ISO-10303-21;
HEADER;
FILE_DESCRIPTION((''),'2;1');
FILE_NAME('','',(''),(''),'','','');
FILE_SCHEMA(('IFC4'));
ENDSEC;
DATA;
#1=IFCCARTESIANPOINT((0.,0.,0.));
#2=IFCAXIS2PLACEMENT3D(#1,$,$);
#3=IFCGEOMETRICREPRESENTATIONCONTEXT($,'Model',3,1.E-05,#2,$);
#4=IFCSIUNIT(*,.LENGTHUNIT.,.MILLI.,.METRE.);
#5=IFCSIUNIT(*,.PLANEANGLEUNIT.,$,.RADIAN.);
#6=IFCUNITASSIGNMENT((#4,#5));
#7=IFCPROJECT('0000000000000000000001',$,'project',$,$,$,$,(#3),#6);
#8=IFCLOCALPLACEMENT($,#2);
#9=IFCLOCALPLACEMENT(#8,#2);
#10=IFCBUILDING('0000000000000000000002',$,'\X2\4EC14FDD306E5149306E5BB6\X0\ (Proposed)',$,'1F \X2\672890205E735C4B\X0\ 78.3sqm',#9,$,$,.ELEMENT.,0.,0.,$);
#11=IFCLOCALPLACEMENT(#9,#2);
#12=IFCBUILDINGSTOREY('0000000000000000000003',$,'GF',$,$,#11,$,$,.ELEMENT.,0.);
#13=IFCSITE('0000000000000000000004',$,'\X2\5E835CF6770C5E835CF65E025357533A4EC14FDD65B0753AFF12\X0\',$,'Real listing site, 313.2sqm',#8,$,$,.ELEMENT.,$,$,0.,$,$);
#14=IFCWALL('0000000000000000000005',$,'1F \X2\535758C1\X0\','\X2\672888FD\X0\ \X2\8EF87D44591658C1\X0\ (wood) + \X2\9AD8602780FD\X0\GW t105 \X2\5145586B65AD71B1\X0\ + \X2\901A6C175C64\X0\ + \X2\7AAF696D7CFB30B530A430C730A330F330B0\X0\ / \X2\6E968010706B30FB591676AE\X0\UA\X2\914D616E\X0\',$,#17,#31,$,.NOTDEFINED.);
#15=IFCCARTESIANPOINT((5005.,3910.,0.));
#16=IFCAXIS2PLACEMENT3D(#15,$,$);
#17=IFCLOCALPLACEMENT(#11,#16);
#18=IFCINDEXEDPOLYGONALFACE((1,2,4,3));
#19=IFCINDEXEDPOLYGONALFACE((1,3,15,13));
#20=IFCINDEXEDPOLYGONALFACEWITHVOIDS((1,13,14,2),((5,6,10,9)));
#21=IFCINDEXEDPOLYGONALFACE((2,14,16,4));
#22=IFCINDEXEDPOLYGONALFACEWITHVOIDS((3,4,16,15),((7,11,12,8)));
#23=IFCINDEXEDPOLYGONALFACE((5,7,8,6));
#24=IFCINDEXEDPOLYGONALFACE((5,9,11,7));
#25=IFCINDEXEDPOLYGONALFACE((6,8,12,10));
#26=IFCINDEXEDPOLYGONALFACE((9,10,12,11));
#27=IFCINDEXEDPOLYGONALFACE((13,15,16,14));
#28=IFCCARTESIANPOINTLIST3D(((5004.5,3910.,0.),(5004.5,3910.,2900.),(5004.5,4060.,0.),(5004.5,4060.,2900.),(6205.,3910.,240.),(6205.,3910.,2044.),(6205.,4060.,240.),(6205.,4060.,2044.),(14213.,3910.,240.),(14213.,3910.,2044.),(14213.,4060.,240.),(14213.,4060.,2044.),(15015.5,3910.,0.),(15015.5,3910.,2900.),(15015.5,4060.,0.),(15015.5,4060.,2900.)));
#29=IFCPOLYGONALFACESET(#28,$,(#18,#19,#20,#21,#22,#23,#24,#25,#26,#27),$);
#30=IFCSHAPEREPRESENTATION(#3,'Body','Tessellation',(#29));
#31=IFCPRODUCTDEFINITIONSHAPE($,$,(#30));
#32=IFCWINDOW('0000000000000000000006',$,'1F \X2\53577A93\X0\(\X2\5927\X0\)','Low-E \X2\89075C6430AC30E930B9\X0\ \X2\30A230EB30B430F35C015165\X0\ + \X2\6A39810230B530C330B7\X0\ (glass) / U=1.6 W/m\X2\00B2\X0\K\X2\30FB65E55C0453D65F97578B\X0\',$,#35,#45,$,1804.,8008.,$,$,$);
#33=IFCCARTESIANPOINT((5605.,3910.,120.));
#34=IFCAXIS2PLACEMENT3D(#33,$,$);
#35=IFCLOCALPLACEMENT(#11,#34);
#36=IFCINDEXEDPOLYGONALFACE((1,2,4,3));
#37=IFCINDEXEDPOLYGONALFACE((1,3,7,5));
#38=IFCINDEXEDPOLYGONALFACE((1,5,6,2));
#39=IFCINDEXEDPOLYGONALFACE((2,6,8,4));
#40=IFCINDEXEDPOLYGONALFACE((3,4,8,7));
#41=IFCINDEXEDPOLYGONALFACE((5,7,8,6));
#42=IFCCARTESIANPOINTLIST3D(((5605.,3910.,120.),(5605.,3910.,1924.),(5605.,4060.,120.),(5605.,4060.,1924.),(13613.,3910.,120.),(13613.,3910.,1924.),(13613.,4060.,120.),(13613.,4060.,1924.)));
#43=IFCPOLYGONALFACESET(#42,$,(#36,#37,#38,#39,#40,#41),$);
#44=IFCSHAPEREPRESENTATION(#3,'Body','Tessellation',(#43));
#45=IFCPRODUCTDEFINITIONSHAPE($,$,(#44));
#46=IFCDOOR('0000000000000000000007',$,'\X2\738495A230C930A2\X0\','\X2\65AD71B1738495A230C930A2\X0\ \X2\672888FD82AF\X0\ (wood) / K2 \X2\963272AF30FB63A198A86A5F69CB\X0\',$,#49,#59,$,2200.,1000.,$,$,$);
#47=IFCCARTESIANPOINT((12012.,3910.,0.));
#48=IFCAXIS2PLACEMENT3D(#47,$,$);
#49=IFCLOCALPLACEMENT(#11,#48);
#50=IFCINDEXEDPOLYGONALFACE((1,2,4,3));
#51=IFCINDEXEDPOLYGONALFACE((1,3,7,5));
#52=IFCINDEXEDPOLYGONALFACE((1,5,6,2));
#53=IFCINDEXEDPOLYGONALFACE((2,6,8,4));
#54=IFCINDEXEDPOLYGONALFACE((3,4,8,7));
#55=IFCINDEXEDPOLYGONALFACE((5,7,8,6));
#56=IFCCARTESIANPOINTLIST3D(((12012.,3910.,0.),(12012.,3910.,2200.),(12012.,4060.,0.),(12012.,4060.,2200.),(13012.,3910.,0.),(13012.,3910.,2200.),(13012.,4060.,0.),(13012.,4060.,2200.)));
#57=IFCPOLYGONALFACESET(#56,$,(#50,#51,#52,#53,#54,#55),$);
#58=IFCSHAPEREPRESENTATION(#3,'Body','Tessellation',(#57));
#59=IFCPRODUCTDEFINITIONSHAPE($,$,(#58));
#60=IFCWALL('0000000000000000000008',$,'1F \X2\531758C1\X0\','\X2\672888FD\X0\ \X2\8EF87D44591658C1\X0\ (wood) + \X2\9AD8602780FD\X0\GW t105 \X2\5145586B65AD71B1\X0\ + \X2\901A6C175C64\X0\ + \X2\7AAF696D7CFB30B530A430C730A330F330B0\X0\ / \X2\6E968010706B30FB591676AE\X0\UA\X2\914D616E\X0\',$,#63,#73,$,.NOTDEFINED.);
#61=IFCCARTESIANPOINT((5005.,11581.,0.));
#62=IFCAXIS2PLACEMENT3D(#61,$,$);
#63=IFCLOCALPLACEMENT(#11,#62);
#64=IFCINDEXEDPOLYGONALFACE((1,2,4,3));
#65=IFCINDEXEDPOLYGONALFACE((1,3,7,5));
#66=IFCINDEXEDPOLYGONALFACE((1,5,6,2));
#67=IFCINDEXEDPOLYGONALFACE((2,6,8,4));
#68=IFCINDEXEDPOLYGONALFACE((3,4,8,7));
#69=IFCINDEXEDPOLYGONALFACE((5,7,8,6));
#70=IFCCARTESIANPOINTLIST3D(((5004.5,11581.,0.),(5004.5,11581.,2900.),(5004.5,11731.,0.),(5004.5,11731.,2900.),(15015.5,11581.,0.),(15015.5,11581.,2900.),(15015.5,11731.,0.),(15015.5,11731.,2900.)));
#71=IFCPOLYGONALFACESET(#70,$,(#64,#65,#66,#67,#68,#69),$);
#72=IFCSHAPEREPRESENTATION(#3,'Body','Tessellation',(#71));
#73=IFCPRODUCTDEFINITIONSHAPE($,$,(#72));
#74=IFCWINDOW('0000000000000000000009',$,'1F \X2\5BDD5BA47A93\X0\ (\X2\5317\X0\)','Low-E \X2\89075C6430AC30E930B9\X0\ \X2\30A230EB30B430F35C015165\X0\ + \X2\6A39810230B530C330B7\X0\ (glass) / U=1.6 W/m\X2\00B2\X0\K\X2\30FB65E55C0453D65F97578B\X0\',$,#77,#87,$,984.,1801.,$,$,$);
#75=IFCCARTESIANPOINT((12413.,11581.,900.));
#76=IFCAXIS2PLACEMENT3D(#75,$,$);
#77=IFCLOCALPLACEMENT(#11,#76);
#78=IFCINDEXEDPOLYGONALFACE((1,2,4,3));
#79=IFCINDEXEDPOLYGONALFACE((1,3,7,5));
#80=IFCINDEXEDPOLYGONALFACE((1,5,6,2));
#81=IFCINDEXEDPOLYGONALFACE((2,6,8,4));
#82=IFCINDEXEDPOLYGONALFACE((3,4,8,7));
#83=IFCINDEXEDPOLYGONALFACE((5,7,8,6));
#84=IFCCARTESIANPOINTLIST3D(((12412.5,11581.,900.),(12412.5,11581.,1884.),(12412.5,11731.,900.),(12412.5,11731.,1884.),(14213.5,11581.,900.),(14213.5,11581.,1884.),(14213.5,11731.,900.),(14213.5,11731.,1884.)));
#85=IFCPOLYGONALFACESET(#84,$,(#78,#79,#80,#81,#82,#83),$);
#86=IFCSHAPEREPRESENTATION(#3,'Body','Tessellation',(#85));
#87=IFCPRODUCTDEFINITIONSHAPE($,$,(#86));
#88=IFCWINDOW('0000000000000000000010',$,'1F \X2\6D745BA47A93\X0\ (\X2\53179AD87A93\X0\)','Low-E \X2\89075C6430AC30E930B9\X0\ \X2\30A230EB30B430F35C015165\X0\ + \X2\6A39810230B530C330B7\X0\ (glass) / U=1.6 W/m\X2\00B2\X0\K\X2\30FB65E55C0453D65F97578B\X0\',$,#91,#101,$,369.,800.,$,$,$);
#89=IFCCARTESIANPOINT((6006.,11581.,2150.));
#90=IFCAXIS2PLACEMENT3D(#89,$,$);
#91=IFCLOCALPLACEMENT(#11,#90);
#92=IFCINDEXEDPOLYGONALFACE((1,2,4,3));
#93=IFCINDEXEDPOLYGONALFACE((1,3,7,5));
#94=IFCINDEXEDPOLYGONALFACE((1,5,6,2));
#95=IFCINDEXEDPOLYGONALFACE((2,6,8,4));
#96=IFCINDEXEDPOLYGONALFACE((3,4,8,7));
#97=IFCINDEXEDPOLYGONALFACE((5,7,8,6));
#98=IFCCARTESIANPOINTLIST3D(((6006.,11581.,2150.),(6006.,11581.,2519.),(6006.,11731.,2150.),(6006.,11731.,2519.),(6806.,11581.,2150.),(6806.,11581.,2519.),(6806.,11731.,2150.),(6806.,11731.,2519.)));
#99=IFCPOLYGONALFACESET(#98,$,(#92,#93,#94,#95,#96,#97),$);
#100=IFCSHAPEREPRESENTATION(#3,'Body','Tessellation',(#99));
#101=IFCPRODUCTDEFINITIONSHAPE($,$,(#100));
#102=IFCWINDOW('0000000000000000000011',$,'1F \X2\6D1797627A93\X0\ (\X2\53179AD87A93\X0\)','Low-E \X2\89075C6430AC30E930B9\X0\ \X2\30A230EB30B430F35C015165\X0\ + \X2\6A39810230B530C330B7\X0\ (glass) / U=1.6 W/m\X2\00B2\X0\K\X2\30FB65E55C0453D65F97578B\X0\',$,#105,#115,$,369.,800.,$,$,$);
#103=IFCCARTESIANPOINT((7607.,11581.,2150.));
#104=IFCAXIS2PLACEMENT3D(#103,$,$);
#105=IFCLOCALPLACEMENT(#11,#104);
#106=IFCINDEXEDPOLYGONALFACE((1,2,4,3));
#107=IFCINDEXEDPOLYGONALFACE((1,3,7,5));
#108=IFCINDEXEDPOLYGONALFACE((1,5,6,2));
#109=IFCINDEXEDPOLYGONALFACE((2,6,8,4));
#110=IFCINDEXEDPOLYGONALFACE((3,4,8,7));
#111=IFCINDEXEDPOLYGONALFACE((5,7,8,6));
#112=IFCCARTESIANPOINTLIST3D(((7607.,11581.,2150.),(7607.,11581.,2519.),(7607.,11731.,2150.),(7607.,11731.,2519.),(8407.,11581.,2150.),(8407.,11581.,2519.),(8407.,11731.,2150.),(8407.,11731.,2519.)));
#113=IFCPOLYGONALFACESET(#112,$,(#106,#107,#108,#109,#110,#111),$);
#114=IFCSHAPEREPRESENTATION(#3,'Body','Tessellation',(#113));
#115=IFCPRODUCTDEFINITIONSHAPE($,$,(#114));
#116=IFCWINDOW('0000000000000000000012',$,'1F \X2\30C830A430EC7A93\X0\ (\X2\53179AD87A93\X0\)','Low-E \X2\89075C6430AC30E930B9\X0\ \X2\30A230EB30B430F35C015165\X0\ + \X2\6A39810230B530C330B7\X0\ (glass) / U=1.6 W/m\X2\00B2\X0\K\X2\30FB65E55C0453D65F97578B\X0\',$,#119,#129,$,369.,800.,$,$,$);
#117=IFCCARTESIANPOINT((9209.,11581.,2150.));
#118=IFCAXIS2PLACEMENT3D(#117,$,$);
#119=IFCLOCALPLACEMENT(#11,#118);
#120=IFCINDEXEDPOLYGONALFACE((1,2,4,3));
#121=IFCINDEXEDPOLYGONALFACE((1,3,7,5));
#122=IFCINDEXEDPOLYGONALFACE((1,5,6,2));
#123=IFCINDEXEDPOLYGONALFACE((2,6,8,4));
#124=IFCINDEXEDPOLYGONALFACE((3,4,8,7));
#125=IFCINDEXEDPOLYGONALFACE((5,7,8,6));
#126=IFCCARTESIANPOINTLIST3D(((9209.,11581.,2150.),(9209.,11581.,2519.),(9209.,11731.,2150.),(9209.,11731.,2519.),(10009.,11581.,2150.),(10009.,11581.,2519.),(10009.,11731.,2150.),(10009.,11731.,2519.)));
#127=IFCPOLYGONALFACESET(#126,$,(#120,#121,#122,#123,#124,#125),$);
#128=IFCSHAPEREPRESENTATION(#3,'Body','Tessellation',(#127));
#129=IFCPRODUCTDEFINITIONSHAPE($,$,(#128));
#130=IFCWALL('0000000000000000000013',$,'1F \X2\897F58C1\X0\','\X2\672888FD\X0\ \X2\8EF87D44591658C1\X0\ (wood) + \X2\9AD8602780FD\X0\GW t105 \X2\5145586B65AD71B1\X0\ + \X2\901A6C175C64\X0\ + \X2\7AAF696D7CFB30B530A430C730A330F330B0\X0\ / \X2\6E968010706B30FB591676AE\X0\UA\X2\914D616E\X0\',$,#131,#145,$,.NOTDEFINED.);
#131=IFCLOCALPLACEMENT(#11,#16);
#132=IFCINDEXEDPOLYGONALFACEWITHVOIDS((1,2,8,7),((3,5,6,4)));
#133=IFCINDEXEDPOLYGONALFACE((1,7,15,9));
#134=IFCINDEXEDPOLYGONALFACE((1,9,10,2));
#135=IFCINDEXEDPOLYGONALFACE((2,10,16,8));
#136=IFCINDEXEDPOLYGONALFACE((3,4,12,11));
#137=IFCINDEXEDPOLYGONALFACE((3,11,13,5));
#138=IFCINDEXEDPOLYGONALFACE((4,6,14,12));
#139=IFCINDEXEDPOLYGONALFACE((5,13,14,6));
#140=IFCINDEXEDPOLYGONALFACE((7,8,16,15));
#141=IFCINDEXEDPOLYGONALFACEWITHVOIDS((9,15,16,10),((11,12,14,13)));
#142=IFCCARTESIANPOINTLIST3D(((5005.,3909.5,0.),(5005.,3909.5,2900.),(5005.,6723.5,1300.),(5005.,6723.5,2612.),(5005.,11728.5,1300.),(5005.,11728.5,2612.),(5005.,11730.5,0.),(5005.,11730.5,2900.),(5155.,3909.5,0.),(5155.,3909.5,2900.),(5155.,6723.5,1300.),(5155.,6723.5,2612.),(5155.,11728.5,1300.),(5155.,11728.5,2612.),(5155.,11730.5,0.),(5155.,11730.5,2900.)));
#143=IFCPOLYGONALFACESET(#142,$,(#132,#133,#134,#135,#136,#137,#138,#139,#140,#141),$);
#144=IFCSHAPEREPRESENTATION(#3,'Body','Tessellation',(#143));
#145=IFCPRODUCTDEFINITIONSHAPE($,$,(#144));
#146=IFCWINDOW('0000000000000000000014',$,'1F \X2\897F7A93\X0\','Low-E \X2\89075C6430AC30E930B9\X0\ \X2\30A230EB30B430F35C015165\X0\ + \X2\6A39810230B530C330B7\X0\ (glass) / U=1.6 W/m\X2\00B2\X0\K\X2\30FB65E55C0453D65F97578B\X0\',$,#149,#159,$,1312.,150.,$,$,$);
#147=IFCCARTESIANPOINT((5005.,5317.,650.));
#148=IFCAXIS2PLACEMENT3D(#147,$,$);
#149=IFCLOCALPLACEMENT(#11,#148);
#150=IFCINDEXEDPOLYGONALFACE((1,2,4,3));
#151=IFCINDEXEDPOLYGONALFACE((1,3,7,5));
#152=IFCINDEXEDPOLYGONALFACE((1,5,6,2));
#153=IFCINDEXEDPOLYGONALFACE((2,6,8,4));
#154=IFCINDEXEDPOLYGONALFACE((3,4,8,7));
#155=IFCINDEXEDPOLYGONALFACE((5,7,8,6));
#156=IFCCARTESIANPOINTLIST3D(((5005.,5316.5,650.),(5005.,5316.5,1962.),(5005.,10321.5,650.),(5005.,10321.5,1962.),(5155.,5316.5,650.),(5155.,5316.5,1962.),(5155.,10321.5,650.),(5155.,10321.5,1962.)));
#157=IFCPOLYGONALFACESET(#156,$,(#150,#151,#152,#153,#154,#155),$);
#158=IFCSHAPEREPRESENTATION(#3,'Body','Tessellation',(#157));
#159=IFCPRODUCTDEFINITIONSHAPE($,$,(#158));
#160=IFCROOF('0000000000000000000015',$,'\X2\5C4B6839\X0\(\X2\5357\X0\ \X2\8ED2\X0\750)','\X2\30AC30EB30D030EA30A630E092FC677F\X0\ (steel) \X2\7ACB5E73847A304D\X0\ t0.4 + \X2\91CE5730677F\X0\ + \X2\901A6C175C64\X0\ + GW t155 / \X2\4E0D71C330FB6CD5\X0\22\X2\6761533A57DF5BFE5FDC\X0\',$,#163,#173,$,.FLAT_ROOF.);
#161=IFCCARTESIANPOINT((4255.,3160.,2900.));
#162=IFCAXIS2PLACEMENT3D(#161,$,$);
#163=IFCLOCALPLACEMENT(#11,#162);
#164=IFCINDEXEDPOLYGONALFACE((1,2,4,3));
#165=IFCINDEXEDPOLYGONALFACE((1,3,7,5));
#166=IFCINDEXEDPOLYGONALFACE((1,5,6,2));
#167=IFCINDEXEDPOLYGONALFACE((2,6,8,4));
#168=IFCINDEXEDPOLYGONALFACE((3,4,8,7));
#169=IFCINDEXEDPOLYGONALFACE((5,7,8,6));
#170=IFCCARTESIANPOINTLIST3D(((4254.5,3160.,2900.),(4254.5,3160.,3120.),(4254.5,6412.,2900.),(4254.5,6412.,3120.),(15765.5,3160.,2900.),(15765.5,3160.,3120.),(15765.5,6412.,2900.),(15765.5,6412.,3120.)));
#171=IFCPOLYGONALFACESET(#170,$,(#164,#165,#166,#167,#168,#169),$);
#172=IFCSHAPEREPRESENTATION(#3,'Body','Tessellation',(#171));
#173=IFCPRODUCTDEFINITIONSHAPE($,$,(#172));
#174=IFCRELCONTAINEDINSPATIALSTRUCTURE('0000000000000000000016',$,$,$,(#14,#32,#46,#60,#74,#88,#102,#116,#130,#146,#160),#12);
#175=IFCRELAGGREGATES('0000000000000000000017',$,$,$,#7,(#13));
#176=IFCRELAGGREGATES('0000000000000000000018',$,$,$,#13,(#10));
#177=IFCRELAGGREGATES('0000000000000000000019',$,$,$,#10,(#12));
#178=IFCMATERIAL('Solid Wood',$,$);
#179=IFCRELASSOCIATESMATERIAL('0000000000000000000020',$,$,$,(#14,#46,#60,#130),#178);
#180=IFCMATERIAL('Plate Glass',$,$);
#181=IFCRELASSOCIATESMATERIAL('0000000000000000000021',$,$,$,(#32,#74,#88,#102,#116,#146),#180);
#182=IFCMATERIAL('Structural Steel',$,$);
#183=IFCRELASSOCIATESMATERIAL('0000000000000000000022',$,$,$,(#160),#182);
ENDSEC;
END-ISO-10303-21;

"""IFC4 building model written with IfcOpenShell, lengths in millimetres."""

from ifc_helpers import new_model, si_unit, frame, frame_2d, origin, place, context, project, spatial, rectangle, extrude, material, element, fill, save


model = new_model("IFC4")

# Units and contexts
model_context = context("Model", 3, precision=1e-05, world=origin())
ifc_project = project(units=[si_unit("LENGTHUNIT", "METRE", prefix="MILLI"), si_unit("PLANEANGLEUNIT", "RADIAN")], contexts=[model_context])

# Site, building, storey
site_placement = place(None, origin())
site = spatial("IfcSite", under=ifc_project, at=site_placement, Name="広島県広島市南区仁保新町２", ObjectType="Real listing site, 313.2sqm", CompositionType="ELEMENT", RefElevation=0.0)
building_placement = place(site_placement, origin())
building = spatial("IfcBuilding", under=site, at=building_placement, Name="仁保の光の家 (Proposed)", ObjectType="1F 木造平屋 78.3sqm", CompositionType="ELEMENT", ElevationOfRefHeight=0.0, ElevationOfTerrain=0.0)
storey_placement = place(building_placement, origin())
storey = spatial("IfcBuildingStorey", under=building, at=storey_placement, Name="GF", CompositionType="ELEMENT", Elevation=0.0)

# Shared definitions
ifc_material_1 = material(Name="Solid Wood")

# Wall, openings, window, door
wall_1_placement = place(storey_placement, frame((5005.0, 3910.0, 0.0)))
wall_1 = element("IfcWall", 1, at=wall_1_placement, inside=storey, material=ifc_material_1, Name="1F 南壁", Description="木製 軸組外壁 (wood) + 高性能GW t105 充填断熱 + 通気層 + 窯業系サイディング / 準耐火・外皮UA配慮", PredefinedType="NOTDEFINED", context=model_context, shape_type="SweptSolid", body=[
    extrude(rectangle(XDim=10011.0, YDim=150.0, at=frame_2d((5005.0, 75.0))), frame((5005.0, 3910.0, 0.0)), (0.0, 0.0, 1.0), 2900.0),
])
opening_1_placement = place(storey_placement, frame((5605.0, 3910.0, 120.0)))
opening_1 = element("IfcOpeningElement", 2, at=opening_1_placement, cuts=wall_1, PredefinedType="NOTDEFINED", context=model_context, shape_type="SweptSolid", body=[
    extrude(rectangle(XDim=8008.0, YDim=150.0, at=frame_2d((4004.0, 75.0))), frame((5605.0, 3910.0, 120.0)), (0.0, 0.0, 1.0), 1804.0),
])
opening_2_placement = place(storey_placement, frame((12012.0, 3910.0, 0.0)))
opening_2 = element("IfcOpeningElement", 3, at=opening_2_placement, cuts=wall_1, PredefinedType="NOTDEFINED", context=model_context, shape_type="SweptSolid", body=[
    extrude(rectangle(XDim=1000.0, YDim=150.0, at=frame_2d((500.0, 75.0))), frame((12012.0, 3910.0, 0.0)), (0.0, 0.0, 1.0), 2200.0),
])
ifc_material_2 = material(Name="Plate Glass")
window_1_placement = place(storey_placement, frame((5605.0, 3910.0, 120.0)))
window_1 = element("IfcWindow", 4, at=window_1_placement, inside=storey, material=ifc_material_2, Name="1F 南窓(大)", Description="Low-E 複層ガラス アルゴン封入 + 樹脂サッシ (glass) / U=1.6 W/m²K・日射取得型", OverallHeight=1804.0, OverallWidth=8008.0, context=model_context, shape_type="SweptSolid", body=[
    extrude(rectangle(XDim=8008.0, YDim=150.0, at=frame_2d((4004.0, 75.0))), frame((5605.0, 3910.0, 120.0)), (0.0, 0.0, 1.0), 1804.0),
])
fill(opening_1, window_1)
door_1_placement = place(storey_placement, frame((12012.0, 3910.0, 0.0)))
door_1 = element("IfcDoor", 5, at=door_1_placement, inside=storey, material=ifc_material_1, Name="玄関ドア", Description="断熱玄関ドア 木製芯 (wood) / K2 防犯・採風機構", OverallHeight=2200.0, OverallWidth=1000.0, context=model_context, shape_type="SweptSolid", body=[
    extrude(rectangle(XDim=1000.0, YDim=150.0, at=frame_2d((500.0, 75.0))), frame((12012.0, 3910.0, 0.0)), (0.0, 0.0, 1.0), 2200.0),
])
fill(opening_2, door_1)

# Wall, openings, windows
wall_2_placement = place(storey_placement, frame((5005.0, 11581.0, 0.0)))
wall_2 = element("IfcWall", 6, at=wall_2_placement, inside=storey, material=ifc_material_1, Name="1F 北壁", Description="木製 軸組外壁 (wood) + 高性能GW t105 充填断熱 + 通気層 + 窯業系サイディング / 準耐火・外皮UA配慮", PredefinedType="NOTDEFINED", context=model_context, shape_type="SweptSolid", body=[
    extrude(rectangle(XDim=10011.0, YDim=150.0, at=frame_2d((5005.0, 75.0))), frame((5005.0, 11581.0, 0.0)), (0.0, 0.0, 1.0), 2900.0),
])
opening_3_placement = place(storey_placement, frame((12413.0, 11581.0, 900.0)))
opening_3 = element("IfcOpeningElement", 7, at=opening_3_placement, cuts=wall_2, PredefinedType="NOTDEFINED", context=model_context, shape_type="SweptSolid", body=[
    extrude(rectangle(XDim=1801.0, YDim=150.0, at=frame_2d((900.0, 75.0))), frame((12413.0, 11581.0, 900.0)), (0.0, 0.0, 1.0), 984.0),
])
opening_4_placement = place(storey_placement, frame((6006.0, 11581.0, 2150.0)))
opening_4 = element("IfcOpeningElement", 8, at=opening_4_placement, cuts=wall_2, PredefinedType="NOTDEFINED", context=model_context, shape_type="SweptSolid", body=[
    extrude(rectangle(XDim=800.0, YDim=150.0, at=frame_2d((400.0, 75.0))), frame((6006.0, 11581.0, 2150.0)), (0.0, 0.0, 1.0), 369.0),
])
opening_5_placement = place(storey_placement, frame((7607.0, 11581.0, 2150.0)))
opening_5 = element("IfcOpeningElement", 9, at=opening_5_placement, cuts=wall_2, PredefinedType="NOTDEFINED", context=model_context, shape_type="SweptSolid", body=[
    extrude(rectangle(XDim=800.0, YDim=150.0, at=frame_2d((400.0, 75.0))), frame((7607.0, 11581.0, 2150.0)), (0.0, 0.0, 1.0), 369.0),
])
opening_6_placement = place(storey_placement, frame((9209.0, 11581.0, 2150.0)))
opening_6 = element("IfcOpeningElement", 10, at=opening_6_placement, cuts=wall_2, PredefinedType="NOTDEFINED", context=model_context, shape_type="SweptSolid", body=[
    extrude(rectangle(XDim=800.0, YDim=150.0, at=frame_2d((400.0, 75.0))), frame((9209.0, 11581.0, 2150.0)), (0.0, 0.0, 1.0), 369.0),
])
window_2_placement = place(storey_placement, frame((12413.0, 11581.0, 900.0)))
window_2 = element("IfcWindow", 11, at=window_2_placement, inside=storey, material=ifc_material_2, Name="1F 寝室窓 (北)", Description="Low-E 複層ガラス アルゴン封入 + 樹脂サッシ (glass) / U=1.6 W/m²K・日射取得型", OverallHeight=984.0, OverallWidth=1801.0, context=model_context, shape_type="SweptSolid", body=[
    extrude(rectangle(XDim=1801.0, YDim=150.0, at=frame_2d((900.0, 75.0))), frame((12413.0, 11581.0, 900.0)), (0.0, 0.0, 1.0), 984.0),
])
fill(opening_3, window_2)
window_3_placement = place(storey_placement, frame((6006.0, 11581.0, 2150.0)))
window_3 = element("IfcWindow", 12, at=window_3_placement, inside=storey, material=ifc_material_2, Name="1F 浴室窓 (北高窓)", Description="Low-E 複層ガラス アルゴン封入 + 樹脂サッシ (glass) / U=1.6 W/m²K・日射取得型", OverallHeight=369.0, OverallWidth=800.0, context=model_context, shape_type="SweptSolid", body=[
    extrude(rectangle(XDim=800.0, YDim=150.0, at=frame_2d((400.0, 75.0))), frame((6006.0, 11581.0, 2150.0)), (0.0, 0.0, 1.0), 369.0),
])
fill(opening_4, window_3)
window_4_placement = place(storey_placement, frame((7607.0, 11581.0, 2150.0)))
window_4 = element("IfcWindow", 13, at=window_4_placement, inside=storey, material=ifc_material_2, Name="1F 洗面窓 (北高窓)", Description="Low-E 複層ガラス アルゴン封入 + 樹脂サッシ (glass) / U=1.6 W/m²K・日射取得型", OverallHeight=369.0, OverallWidth=800.0, context=model_context, shape_type="SweptSolid", body=[
    extrude(rectangle(XDim=800.0, YDim=150.0, at=frame_2d((400.0, 75.0))), frame((7607.0, 11581.0, 2150.0)), (0.0, 0.0, 1.0), 369.0),
])
fill(opening_5, window_4)
window_5_placement = place(storey_placement, frame((9209.0, 11581.0, 2150.0)))
window_5 = element("IfcWindow", 14, at=window_5_placement, inside=storey, material=ifc_material_2, Name="1F トイレ窓 (北高窓)", Description="Low-E 複層ガラス アルゴン封入 + 樹脂サッシ (glass) / U=1.6 W/m²K・日射取得型", OverallHeight=369.0, OverallWidth=800.0, context=model_context, shape_type="SweptSolid", body=[
    extrude(rectangle(XDim=800.0, YDim=150.0, at=frame_2d((400.0, 75.0))), frame((9209.0, 11581.0, 2150.0)), (0.0, 0.0, 1.0), 369.0),
])
fill(opening_6, window_5)

# Wall, opening, window
wall_3_placement = place(storey_placement, frame((5005.0, 3910.0, 0.0)))
wall_3 = element("IfcWall", 15, at=wall_3_placement, inside=storey, material=ifc_material_1, Name="1F 西壁", Description="木製 軸組外壁 (wood) + 高性能GW t105 充填断熱 + 通気層 + 窯業系サイディング / 準耐火・外皮UA配慮", PredefinedType="NOTDEFINED", context=model_context, shape_type="SweptSolid", body=[
    extrude(rectangle(XDim=150.0, YDim=7821.0, at=frame_2d((75.0, 3910.0))), frame((5005.0, 3910.0, 0.0)), (0.0, 0.0, 1.0), 2900.0),
])
opening_7_placement = place(storey_placement, frame((5005.0, 5317.0, 650.0)))
opening_7 = element("IfcOpeningElement", 16, at=opening_7_placement, cuts=wall_3, PredefinedType="NOTDEFINED", context=model_context, shape_type="SweptSolid", body=[
    extrude(rectangle(XDim=150.0, YDim=5005.0, at=frame_2d((75.0, 2502.0))), frame((5005.0, 5317.0, 650.0)), (0.0, 0.0, 1.0), 1312.0),
])
window_6_placement = place(storey_placement, frame((5005.0, 5317.0, 650.0)))
window_6 = element("IfcWindow", 17, at=window_6_placement, inside=storey, material=ifc_material_2, Name="1F 西窓", Description="Low-E 複層ガラス アルゴン封入 + 樹脂サッシ (glass) / U=1.6 W/m²K・日射取得型", OverallHeight=1312.0, OverallWidth=150.0, context=model_context, shape_type="SweptSolid", body=[
    extrude(rectangle(XDim=150.0, YDim=5005.0, at=frame_2d((75.0, 2502.0))), frame((5005.0, 5317.0, 650.0)), (0.0, 0.0, 1.0), 1312.0),
])
fill(opening_7, window_6)

# Roof
ifc_material_3 = material(Name="Structural Steel")
roof_1_placement = place(storey_placement, frame((4255.0, 3160.0, 2900.0)))
element("IfcRoof", 18, at=roof_1_placement, inside=storey, material=ifc_material_3, Name="屋根(南 軒750)", Description="ガルバリウム鋼板 (steel) 立平葺き t0.4 + 野地板 + 通気層 + GW t155 / 不燃・法22条区域対応", PredefinedType="FLAT_ROOF", context=model_context, shape_type="SweptSolid", body=[
    extrude(rectangle(XDim=11511.0, YDim=3252.0, at=frame_2d((5755.0, 1626.0))), frame((4255.0, 3160.0, 2900.0)), (0.0, 0.0, 1.0), 220.0),
])

save(model, "model.ifc")
